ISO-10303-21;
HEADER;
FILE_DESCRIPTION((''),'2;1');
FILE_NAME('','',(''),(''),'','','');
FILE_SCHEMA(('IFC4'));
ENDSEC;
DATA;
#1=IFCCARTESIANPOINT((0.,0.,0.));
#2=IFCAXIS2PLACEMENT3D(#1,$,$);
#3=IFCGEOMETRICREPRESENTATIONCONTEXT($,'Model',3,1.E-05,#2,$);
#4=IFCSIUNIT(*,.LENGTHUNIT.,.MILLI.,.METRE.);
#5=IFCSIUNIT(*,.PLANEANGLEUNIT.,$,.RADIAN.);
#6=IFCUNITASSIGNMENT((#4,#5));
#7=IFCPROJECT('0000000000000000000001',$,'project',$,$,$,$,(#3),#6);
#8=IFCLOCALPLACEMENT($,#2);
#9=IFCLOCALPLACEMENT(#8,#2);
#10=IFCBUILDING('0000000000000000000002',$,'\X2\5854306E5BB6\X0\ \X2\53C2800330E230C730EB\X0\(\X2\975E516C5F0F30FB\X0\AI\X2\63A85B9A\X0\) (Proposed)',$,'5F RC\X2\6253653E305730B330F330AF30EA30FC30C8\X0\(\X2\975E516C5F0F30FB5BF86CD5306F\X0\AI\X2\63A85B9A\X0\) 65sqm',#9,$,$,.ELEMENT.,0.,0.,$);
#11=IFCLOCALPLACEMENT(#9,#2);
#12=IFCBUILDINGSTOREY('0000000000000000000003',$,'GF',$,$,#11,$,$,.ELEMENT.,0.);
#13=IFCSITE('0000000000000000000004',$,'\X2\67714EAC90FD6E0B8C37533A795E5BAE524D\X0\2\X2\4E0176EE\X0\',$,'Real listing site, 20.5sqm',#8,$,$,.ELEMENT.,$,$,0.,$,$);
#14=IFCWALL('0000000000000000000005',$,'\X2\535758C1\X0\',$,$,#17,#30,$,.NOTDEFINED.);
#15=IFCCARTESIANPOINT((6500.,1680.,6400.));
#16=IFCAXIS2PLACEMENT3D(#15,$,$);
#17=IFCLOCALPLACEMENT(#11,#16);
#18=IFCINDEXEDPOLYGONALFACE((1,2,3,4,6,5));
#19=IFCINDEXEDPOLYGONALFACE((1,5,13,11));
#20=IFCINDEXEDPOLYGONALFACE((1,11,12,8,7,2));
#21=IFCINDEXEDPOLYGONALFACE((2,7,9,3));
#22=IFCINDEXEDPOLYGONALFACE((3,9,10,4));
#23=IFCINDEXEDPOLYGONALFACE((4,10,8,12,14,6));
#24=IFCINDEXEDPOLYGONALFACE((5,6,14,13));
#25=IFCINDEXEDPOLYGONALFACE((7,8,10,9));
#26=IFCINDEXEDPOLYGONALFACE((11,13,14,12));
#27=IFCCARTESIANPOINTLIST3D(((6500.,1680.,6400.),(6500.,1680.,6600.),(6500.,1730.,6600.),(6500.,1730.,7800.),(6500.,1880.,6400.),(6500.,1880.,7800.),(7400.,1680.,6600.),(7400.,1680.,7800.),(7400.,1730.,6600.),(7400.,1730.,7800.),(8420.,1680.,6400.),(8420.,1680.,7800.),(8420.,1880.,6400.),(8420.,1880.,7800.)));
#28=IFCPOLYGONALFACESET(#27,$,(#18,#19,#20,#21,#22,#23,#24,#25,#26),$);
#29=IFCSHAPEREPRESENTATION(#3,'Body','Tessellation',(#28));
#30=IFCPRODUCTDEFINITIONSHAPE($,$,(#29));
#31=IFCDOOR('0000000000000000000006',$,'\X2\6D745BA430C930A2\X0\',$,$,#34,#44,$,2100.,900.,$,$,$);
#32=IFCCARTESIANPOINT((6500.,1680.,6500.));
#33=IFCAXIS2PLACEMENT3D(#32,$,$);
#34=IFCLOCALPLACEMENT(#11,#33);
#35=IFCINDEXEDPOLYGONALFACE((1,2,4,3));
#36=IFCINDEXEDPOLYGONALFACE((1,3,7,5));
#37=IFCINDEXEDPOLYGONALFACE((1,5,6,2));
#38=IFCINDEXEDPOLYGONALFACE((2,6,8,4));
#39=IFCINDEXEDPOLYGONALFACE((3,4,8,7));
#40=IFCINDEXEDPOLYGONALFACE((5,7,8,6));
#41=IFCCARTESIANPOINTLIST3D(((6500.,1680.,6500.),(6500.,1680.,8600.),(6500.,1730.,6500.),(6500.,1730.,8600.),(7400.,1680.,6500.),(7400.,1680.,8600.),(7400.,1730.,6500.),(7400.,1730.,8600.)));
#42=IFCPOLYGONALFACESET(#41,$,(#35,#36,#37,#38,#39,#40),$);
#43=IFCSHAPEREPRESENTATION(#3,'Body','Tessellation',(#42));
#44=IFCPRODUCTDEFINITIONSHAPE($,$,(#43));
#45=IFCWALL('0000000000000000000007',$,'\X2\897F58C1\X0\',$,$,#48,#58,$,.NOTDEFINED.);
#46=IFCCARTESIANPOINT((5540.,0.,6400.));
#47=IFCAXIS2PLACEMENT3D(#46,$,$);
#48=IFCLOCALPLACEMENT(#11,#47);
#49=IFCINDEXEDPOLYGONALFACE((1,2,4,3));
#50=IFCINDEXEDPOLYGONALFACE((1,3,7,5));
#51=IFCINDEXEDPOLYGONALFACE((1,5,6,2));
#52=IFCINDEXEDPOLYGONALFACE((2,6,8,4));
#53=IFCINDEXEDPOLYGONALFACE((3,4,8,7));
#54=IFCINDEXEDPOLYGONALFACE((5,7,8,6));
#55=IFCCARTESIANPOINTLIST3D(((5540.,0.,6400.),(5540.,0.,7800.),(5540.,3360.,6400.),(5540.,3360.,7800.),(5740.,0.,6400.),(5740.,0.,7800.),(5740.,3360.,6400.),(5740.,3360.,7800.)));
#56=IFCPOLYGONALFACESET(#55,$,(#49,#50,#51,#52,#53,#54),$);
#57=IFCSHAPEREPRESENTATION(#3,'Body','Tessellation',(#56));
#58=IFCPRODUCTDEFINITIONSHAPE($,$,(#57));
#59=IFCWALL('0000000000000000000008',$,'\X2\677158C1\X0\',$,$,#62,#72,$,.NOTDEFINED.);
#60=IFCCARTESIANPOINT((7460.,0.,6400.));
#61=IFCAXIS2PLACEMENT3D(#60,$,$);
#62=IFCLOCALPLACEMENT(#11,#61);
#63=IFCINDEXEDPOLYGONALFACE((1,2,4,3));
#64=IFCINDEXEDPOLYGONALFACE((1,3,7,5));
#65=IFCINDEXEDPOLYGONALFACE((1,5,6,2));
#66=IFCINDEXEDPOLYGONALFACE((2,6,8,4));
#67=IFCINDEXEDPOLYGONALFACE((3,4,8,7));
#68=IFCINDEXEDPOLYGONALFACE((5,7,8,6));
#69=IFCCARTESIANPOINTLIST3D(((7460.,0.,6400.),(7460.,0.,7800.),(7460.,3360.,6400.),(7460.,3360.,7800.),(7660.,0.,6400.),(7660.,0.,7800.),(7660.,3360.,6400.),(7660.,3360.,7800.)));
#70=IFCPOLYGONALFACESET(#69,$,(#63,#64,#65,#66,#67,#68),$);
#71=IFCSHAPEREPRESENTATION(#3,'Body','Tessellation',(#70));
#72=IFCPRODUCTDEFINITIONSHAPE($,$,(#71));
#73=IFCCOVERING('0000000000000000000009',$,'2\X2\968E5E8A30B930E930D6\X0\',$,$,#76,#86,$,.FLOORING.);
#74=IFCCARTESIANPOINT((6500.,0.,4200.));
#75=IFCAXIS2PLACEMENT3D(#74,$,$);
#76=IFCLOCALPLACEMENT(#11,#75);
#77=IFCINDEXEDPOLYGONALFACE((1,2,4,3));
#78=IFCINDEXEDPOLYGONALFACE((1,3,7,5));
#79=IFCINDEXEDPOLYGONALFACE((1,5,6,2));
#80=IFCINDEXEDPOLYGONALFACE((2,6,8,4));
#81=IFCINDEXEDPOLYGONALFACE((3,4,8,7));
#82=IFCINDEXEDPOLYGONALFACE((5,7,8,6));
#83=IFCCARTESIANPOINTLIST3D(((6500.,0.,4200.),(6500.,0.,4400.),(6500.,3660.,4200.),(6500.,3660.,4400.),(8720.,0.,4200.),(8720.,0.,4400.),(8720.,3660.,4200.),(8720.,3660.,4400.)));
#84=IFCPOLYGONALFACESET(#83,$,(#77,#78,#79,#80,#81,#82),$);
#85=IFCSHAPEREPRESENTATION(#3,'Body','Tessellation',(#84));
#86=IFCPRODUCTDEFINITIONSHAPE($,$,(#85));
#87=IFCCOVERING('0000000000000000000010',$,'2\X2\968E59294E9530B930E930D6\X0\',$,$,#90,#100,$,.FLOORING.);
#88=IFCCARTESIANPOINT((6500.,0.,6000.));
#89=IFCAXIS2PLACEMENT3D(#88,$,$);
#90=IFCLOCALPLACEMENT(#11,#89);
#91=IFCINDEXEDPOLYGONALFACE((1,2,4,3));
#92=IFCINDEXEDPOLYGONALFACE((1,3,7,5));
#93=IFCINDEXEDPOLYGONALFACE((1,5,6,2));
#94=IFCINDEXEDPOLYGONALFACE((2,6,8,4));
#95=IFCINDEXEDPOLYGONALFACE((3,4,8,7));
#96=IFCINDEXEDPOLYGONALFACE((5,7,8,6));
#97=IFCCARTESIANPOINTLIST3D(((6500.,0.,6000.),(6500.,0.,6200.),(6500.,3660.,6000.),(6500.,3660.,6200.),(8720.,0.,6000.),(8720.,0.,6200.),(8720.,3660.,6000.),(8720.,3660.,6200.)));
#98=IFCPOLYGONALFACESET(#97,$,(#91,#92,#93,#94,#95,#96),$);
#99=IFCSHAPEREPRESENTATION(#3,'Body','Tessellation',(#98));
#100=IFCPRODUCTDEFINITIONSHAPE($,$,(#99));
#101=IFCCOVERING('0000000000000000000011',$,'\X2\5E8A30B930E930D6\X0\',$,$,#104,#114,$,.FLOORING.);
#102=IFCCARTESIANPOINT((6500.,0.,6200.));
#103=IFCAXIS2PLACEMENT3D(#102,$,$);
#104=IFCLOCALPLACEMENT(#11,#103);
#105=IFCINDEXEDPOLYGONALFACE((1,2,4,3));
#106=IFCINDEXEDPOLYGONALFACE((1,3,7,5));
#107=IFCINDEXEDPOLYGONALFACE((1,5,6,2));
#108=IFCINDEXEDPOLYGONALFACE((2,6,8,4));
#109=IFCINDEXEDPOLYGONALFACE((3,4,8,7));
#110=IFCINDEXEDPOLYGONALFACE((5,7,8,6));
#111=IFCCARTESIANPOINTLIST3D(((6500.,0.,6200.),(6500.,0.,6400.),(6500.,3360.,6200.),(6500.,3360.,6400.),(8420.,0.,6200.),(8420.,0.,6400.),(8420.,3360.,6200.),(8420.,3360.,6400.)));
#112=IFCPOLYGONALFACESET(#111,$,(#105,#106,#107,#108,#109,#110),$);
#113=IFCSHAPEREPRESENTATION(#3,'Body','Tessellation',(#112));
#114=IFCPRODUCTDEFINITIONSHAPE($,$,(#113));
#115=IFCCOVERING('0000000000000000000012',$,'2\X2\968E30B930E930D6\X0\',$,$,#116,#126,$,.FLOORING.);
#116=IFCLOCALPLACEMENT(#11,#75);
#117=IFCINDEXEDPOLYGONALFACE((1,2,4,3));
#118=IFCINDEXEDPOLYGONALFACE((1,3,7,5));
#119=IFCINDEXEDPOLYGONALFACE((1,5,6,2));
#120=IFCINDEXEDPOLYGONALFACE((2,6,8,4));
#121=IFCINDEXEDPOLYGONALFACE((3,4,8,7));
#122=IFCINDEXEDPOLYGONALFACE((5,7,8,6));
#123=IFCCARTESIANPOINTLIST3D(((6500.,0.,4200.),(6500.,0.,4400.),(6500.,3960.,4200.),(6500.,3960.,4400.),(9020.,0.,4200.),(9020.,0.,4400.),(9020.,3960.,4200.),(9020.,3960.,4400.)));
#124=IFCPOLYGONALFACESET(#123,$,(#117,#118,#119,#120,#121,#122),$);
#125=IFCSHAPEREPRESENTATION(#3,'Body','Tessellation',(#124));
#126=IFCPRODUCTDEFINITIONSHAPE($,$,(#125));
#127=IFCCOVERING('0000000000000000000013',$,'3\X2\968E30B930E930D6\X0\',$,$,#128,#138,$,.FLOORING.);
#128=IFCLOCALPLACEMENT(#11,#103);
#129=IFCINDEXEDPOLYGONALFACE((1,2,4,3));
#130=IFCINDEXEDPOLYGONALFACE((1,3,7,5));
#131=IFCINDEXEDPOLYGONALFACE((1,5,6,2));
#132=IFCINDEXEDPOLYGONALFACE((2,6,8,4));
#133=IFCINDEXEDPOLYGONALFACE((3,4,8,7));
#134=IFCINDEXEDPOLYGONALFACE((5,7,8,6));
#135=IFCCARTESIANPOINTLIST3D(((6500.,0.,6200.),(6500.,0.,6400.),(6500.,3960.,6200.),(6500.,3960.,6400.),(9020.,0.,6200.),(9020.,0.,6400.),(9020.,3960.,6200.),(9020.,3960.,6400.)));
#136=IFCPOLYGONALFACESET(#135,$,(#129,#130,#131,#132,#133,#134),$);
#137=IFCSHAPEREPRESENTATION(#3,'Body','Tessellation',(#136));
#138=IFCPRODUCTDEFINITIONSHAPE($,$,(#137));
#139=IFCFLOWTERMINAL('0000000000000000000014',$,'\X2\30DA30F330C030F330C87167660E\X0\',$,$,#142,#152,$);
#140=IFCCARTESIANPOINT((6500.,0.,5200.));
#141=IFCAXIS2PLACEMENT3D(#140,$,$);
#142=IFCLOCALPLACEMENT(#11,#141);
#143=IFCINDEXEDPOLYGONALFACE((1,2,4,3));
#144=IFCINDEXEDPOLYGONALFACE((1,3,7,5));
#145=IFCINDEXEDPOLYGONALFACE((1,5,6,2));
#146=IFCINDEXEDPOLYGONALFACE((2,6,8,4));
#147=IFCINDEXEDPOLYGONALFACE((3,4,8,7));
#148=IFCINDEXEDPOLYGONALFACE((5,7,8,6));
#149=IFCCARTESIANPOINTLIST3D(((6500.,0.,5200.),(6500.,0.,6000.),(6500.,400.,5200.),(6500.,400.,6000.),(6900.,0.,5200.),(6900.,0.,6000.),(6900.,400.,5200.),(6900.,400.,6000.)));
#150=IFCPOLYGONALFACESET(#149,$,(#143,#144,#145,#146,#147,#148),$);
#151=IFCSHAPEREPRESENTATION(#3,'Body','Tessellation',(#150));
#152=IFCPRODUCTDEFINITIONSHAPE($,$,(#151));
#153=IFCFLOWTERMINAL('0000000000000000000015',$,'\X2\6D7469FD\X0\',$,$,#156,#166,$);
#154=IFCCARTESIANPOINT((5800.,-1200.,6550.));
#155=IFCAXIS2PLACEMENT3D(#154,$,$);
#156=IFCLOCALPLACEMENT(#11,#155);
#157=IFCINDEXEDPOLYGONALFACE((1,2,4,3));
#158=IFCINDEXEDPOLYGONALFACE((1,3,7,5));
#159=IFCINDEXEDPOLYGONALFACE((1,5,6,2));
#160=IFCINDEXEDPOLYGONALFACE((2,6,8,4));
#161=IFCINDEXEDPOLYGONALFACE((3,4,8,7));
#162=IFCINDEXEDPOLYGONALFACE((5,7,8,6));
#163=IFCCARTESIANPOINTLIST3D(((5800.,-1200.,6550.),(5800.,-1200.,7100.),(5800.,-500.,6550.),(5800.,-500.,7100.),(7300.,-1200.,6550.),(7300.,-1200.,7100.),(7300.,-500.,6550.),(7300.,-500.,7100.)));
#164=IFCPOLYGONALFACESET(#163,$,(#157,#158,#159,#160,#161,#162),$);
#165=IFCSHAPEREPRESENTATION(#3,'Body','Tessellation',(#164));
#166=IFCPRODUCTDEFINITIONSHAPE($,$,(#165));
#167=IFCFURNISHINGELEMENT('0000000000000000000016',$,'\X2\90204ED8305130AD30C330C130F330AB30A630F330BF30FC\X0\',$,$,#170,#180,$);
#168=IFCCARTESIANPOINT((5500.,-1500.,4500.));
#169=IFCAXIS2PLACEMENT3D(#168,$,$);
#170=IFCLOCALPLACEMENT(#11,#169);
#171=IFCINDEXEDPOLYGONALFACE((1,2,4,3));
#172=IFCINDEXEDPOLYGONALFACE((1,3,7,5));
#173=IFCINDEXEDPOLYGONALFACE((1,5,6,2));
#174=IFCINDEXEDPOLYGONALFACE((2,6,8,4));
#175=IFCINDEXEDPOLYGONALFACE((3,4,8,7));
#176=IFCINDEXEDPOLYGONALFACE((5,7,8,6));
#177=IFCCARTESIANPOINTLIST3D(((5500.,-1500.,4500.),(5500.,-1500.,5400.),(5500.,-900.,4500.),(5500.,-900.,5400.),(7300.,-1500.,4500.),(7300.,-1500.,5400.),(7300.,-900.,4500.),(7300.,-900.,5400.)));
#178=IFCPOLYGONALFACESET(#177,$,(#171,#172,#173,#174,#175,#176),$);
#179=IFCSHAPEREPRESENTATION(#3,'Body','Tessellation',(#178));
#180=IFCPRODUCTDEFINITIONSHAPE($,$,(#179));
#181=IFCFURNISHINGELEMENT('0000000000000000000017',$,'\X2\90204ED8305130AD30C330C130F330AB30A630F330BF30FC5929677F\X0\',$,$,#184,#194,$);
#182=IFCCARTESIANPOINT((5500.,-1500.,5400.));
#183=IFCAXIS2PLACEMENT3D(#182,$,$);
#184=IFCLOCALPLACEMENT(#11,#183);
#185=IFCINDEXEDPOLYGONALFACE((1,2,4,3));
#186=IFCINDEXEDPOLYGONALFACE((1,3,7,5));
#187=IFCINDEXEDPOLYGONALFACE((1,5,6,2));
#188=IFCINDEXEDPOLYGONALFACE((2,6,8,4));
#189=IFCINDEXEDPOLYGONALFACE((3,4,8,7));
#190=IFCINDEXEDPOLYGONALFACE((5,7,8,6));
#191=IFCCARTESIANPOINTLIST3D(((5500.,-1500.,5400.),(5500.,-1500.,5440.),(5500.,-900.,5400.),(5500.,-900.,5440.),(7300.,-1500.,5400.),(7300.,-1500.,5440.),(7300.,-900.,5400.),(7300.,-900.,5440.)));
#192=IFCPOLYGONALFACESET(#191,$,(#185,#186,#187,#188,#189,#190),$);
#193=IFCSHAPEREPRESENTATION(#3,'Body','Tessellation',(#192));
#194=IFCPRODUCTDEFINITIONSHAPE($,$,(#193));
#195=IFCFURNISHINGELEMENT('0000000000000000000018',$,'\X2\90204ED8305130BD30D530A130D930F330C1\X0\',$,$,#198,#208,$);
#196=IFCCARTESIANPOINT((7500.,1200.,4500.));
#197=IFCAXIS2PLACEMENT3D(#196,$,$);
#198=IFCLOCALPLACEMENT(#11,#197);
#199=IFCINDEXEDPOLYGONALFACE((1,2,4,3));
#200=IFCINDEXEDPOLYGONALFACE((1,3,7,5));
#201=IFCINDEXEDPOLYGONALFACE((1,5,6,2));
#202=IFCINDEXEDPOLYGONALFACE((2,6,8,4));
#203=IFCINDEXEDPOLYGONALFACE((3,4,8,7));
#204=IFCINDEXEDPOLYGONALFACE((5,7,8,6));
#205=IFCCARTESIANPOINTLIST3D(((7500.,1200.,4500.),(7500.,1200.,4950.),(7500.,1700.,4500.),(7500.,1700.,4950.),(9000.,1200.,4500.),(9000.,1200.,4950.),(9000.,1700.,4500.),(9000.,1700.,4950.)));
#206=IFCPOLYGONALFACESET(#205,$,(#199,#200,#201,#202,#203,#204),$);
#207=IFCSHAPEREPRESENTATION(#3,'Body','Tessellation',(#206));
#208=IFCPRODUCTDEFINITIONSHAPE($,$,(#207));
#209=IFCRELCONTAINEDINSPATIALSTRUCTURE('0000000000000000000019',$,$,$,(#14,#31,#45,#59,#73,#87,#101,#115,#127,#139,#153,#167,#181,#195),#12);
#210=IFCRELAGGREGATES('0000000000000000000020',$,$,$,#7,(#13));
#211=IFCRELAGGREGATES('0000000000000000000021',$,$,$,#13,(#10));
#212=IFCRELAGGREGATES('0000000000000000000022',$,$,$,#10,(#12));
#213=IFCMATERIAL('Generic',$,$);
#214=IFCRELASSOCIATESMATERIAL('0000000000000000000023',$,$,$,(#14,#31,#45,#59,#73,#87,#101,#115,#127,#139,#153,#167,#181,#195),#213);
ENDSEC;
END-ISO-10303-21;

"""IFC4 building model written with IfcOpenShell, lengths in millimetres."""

from ifc_helpers import new_model, si_unit, frame, frame_2d, origin, place, context, project, spatial, rectangle, extrude, material, element, fill, save


model = new_model("IFC4")

# Units and contexts
model_context = context("Model", 3, precision=1e-05, world=origin())
ifc_project = project(units=[si_unit("LENGTHUNIT", "METRE", prefix="MILLI"), si_unit("PLANEANGLEUNIT", "RADIAN")], contexts=[model_context])

# Site, building, storey
site_placement = place(None, origin())
site = spatial("IfcSite", under=ifc_project, at=site_placement, Name="東京都渋谷区神宮前2丁目", ObjectType="Real listing site, 20.5sqm", CompositionType="ELEMENT", RefElevation=0.0)
building_placement = place(site_placement, origin())
building = spatial("IfcBuilding", under=site, at=building_placement, Name="塔の家 参考モデル(非公式・AI推定) (Proposed)", ObjectType="5F RC打放しコンクリート(非公式・寸法はAI推定) 65sqm", CompositionType="ELEMENT", ElevationOfRefHeight=0.0, ElevationOfTerrain=0.0)
storey_placement = place(building_placement, origin())
storey = spatial("IfcBuildingStorey", under=building, at=storey_placement, Name="GF", CompositionType="ELEMENT", Elevation=0.0)

# Shared definitions
ifc_material = material(Name="Generic")

# Wall, opening, door
wall_1_placement = place(storey_placement, frame((6500.0, 1680.0, 6400.0)))
wall_1 = element("IfcWall", 1, at=wall_1_placement, inside=storey, material=ifc_material, Name="南壁", PredefinedType="NOTDEFINED", context=model_context, shape_type="SweptSolid", body=[
    extrude(rectangle(XDim=1920.0, YDim=200.0, at=frame_2d((960.0, 100.0))), frame((6500.0, 1680.0, 6400.0)), (0.0, 0.0, 1.0), 1400.0),
])
opening_1_placement = place(storey_placement, frame((6500.0, 1680.0, 6500.0)))
opening_1 = element("IfcOpeningElement", 2, at=opening_1_placement, cuts=wall_1, PredefinedType="NOTDEFINED", context=model_context, shape_type="SweptSolid", body=[
    extrude(rectangle(XDim=900.0, YDim=50.0, at=frame_2d((450.0, 25.0))), frame((6500.0, 1680.0, 6500.0)), (0.0, 0.0, 1.0), 2100.0),
])
door_placement = place(storey_placement, frame((6500.0, 1680.0, 6500.0)))
door = element("IfcDoor", 3, at=door_placement, inside=storey, material=ifc_material, Name="浴室ドア", OverallHeight=2100.0, OverallWidth=900.0, context=model_context, shape_type="SweptSolid", body=[
    extrude(rectangle(XDim=900.0, YDim=50.0, at=frame_2d((450.0, 25.0))), frame((6500.0, 1680.0, 6500.0)), (0.0, 0.0, 1.0), 2100.0),
])
fill(opening_1, door)

# Walls
wall_2_placement = place(storey_placement, frame((5540.0, 0.0, 6400.0)))
element("IfcWall", 4, at=wall_2_placement, inside=storey, material=ifc_material, Name="西壁", PredefinedType="NOTDEFINED", context=model_context, shape_type="SweptSolid", body=[
    extrude(rectangle(XDim=200.0, YDim=3360.0, at=frame_2d((100.0, 1680.0))), frame((5540.0, 0.0, 6400.0)), (0.0, 0.0, 1.0), 1400.0),
])
wall_3_placement = place(storey_placement, frame((7460.0, 0.0, 6400.0)))
element("IfcWall", 5, at=wall_3_placement, inside=storey, material=ifc_material, Name="東壁", PredefinedType="NOTDEFINED", context=model_context, shape_type="SweptSolid", body=[
    extrude(rectangle(XDim=200.0, YDim=3360.0, at=frame_2d((100.0, 1680.0))), frame((7460.0, 0.0, 6400.0)), (0.0, 0.0, 1.0), 1400.0),
])

# Coverings
covering_1_placement = place(storey_placement, frame((6500.0, 0.0, 4200.0)))
element("IfcCovering", 6, at=covering_1_placement, inside=storey, material=ifc_material, Name="2階床スラブ", PredefinedType="FLOORING", context=model_context, shape_type="SweptSolid", body=[
    extrude(rectangle(XDim=2220.0, YDim=3660.0, at=frame_2d((1110.0, 1830.0))), frame((6500.0, 0.0, 4200.0)), (0.0, 0.0, 1.0), 200.0),
])
covering_2_placement = place(storey_placement, frame((6500.0, 0.0, 6000.0)))
element("IfcCovering", 7, at=covering_2_placement, inside=storey, material=ifc_material, Name="2階天井スラブ", PredefinedType="FLOORING", context=model_context, shape_type="SweptSolid", body=[
    extrude(rectangle(XDim=2220.0, YDim=3660.0, at=frame_2d((1110.0, 1830.0))), frame((6500.0, 0.0, 6000.0)), (0.0, 0.0, 1.0), 200.0),
])
covering_3_placement = place(storey_placement, frame((6500.0, 0.0, 6200.0)))
element("IfcCovering", 8, at=covering_3_placement, inside=storey, material=ifc_material, Name="床スラブ", PredefinedType="FLOORING", context=model_context, shape_type="SweptSolid", body=[
    extrude(rectangle(XDim=1920.0, YDim=3360.0, at=frame_2d((960.0, 1680.0))), frame((6500.0, 0.0, 6200.0)), (0.0, 0.0, 1.0), 200.0),
])
covering_4_placement = place(storey_placement, frame((6500.0, 0.0, 4200.0)))
element("IfcCovering", 9, at=covering_4_placement, inside=storey, material=ifc_material, Name="2階スラブ", PredefinedType="FLOORING", context=model_context, shape_type="SweptSolid", body=[
    extrude(rectangle(XDim=2520.0, YDim=3960.0, at=frame_2d((1260.0, 1980.0))), frame((6500.0, 0.0, 4200.0)), (0.0, 0.0, 1.0), 200.0),
])
covering_5_placement = place(storey_placement, frame((6500.0, 0.0, 6200.0)))
element("IfcCovering", 10, at=covering_5_placement, inside=storey, material=ifc_material, Name="3階スラブ", PredefinedType="FLOORING", context=model_context, shape_type="SweptSolid", body=[
    extrude(rectangle(XDim=2520.0, YDim=3960.0, at=frame_2d((1260.0, 1980.0))), frame((6500.0, 0.0, 6200.0)), (0.0, 0.0, 1.0), 200.0),
])

# Flow terminals
flow_terminal_1_placement = place(storey_placement, frame((6500.0, 0.0, 5200.0)))
element("IfcFlowTerminal", 11, at=flow_terminal_1_placement, inside=storey, material=ifc_material, Name="ペンダント照明", context=model_context, shape_type="SweptSolid", body=[
    extrude(rectangle(XDim=400.0, YDim=400.0, at=frame_2d((200.0, 200.0))), frame((6500.0, 0.0, 5200.0)), (0.0, 0.0, 1.0), 800.0),
])
flow_terminal_2_placement = place(storey_placement, frame((5800.0, -1200.0, 6550.0)))
element("IfcFlowTerminal", 12, at=flow_terminal_2_placement, inside=storey, material=ifc_material, Name="浴槽", context=model_context, shape_type="SweptSolid", body=[
    extrude(rectangle(XDim=1500.0, YDim=700.0, at=frame_2d((750.0, 350.0))), frame((5800.0, -1200.0, 6550.0)), (0.0, 0.0, 1.0), 550.0),
])

# Furnishing elements
furnishing_1_placement = place(storey_placement, frame((5500.0, -1500.0, 4500.0)))
element("IfcFurnishingElement", 13, at=furnishing_1_placement, inside=storey, material=ifc_material, Name="造付けキッチンカウンター", context=model_context, shape_type="SweptSolid", body=[
    extrude(rectangle(XDim=1800.0, YDim=600.0, at=frame_2d((900.0, 300.0))), frame((5500.0, -1500.0, 4500.0)), (0.0, 0.0, 1.0), 900.0),
])
furnishing_2_placement = place(storey_placement, frame((5500.0, -1500.0, 5400.0)))
element("IfcFurnishingElement", 14, at=furnishing_2_placement, inside=storey, material=ifc_material, Name="造付けキッチンカウンター天板", context=model_context, shape_type="SweptSolid", body=[
    extrude(rectangle(XDim=1800.0, YDim=600.0, at=frame_2d((900.0, 300.0))), frame((5500.0, -1500.0, 5400.0)), (0.0, 0.0, 1.0), 40.0),
])
furnishing_3_placement = place(storey_placement, frame((7500.0, 1200.0, 4500.0)))
element("IfcFurnishingElement", 15, at=furnishing_3_placement, inside=storey, material=ifc_material, Name="造付けソファベンチ", context=model_context, shape_type="SweptSolid", body=[
    extrude(rectangle(XDim=1500.0, YDim=500.0, at=frame_2d((750.0, 250.0))), frame((7500.0, 1200.0, 4500.0)), (0.0, 0.0, 1.0), 450.0),
])

save(model, "model.ifc")
